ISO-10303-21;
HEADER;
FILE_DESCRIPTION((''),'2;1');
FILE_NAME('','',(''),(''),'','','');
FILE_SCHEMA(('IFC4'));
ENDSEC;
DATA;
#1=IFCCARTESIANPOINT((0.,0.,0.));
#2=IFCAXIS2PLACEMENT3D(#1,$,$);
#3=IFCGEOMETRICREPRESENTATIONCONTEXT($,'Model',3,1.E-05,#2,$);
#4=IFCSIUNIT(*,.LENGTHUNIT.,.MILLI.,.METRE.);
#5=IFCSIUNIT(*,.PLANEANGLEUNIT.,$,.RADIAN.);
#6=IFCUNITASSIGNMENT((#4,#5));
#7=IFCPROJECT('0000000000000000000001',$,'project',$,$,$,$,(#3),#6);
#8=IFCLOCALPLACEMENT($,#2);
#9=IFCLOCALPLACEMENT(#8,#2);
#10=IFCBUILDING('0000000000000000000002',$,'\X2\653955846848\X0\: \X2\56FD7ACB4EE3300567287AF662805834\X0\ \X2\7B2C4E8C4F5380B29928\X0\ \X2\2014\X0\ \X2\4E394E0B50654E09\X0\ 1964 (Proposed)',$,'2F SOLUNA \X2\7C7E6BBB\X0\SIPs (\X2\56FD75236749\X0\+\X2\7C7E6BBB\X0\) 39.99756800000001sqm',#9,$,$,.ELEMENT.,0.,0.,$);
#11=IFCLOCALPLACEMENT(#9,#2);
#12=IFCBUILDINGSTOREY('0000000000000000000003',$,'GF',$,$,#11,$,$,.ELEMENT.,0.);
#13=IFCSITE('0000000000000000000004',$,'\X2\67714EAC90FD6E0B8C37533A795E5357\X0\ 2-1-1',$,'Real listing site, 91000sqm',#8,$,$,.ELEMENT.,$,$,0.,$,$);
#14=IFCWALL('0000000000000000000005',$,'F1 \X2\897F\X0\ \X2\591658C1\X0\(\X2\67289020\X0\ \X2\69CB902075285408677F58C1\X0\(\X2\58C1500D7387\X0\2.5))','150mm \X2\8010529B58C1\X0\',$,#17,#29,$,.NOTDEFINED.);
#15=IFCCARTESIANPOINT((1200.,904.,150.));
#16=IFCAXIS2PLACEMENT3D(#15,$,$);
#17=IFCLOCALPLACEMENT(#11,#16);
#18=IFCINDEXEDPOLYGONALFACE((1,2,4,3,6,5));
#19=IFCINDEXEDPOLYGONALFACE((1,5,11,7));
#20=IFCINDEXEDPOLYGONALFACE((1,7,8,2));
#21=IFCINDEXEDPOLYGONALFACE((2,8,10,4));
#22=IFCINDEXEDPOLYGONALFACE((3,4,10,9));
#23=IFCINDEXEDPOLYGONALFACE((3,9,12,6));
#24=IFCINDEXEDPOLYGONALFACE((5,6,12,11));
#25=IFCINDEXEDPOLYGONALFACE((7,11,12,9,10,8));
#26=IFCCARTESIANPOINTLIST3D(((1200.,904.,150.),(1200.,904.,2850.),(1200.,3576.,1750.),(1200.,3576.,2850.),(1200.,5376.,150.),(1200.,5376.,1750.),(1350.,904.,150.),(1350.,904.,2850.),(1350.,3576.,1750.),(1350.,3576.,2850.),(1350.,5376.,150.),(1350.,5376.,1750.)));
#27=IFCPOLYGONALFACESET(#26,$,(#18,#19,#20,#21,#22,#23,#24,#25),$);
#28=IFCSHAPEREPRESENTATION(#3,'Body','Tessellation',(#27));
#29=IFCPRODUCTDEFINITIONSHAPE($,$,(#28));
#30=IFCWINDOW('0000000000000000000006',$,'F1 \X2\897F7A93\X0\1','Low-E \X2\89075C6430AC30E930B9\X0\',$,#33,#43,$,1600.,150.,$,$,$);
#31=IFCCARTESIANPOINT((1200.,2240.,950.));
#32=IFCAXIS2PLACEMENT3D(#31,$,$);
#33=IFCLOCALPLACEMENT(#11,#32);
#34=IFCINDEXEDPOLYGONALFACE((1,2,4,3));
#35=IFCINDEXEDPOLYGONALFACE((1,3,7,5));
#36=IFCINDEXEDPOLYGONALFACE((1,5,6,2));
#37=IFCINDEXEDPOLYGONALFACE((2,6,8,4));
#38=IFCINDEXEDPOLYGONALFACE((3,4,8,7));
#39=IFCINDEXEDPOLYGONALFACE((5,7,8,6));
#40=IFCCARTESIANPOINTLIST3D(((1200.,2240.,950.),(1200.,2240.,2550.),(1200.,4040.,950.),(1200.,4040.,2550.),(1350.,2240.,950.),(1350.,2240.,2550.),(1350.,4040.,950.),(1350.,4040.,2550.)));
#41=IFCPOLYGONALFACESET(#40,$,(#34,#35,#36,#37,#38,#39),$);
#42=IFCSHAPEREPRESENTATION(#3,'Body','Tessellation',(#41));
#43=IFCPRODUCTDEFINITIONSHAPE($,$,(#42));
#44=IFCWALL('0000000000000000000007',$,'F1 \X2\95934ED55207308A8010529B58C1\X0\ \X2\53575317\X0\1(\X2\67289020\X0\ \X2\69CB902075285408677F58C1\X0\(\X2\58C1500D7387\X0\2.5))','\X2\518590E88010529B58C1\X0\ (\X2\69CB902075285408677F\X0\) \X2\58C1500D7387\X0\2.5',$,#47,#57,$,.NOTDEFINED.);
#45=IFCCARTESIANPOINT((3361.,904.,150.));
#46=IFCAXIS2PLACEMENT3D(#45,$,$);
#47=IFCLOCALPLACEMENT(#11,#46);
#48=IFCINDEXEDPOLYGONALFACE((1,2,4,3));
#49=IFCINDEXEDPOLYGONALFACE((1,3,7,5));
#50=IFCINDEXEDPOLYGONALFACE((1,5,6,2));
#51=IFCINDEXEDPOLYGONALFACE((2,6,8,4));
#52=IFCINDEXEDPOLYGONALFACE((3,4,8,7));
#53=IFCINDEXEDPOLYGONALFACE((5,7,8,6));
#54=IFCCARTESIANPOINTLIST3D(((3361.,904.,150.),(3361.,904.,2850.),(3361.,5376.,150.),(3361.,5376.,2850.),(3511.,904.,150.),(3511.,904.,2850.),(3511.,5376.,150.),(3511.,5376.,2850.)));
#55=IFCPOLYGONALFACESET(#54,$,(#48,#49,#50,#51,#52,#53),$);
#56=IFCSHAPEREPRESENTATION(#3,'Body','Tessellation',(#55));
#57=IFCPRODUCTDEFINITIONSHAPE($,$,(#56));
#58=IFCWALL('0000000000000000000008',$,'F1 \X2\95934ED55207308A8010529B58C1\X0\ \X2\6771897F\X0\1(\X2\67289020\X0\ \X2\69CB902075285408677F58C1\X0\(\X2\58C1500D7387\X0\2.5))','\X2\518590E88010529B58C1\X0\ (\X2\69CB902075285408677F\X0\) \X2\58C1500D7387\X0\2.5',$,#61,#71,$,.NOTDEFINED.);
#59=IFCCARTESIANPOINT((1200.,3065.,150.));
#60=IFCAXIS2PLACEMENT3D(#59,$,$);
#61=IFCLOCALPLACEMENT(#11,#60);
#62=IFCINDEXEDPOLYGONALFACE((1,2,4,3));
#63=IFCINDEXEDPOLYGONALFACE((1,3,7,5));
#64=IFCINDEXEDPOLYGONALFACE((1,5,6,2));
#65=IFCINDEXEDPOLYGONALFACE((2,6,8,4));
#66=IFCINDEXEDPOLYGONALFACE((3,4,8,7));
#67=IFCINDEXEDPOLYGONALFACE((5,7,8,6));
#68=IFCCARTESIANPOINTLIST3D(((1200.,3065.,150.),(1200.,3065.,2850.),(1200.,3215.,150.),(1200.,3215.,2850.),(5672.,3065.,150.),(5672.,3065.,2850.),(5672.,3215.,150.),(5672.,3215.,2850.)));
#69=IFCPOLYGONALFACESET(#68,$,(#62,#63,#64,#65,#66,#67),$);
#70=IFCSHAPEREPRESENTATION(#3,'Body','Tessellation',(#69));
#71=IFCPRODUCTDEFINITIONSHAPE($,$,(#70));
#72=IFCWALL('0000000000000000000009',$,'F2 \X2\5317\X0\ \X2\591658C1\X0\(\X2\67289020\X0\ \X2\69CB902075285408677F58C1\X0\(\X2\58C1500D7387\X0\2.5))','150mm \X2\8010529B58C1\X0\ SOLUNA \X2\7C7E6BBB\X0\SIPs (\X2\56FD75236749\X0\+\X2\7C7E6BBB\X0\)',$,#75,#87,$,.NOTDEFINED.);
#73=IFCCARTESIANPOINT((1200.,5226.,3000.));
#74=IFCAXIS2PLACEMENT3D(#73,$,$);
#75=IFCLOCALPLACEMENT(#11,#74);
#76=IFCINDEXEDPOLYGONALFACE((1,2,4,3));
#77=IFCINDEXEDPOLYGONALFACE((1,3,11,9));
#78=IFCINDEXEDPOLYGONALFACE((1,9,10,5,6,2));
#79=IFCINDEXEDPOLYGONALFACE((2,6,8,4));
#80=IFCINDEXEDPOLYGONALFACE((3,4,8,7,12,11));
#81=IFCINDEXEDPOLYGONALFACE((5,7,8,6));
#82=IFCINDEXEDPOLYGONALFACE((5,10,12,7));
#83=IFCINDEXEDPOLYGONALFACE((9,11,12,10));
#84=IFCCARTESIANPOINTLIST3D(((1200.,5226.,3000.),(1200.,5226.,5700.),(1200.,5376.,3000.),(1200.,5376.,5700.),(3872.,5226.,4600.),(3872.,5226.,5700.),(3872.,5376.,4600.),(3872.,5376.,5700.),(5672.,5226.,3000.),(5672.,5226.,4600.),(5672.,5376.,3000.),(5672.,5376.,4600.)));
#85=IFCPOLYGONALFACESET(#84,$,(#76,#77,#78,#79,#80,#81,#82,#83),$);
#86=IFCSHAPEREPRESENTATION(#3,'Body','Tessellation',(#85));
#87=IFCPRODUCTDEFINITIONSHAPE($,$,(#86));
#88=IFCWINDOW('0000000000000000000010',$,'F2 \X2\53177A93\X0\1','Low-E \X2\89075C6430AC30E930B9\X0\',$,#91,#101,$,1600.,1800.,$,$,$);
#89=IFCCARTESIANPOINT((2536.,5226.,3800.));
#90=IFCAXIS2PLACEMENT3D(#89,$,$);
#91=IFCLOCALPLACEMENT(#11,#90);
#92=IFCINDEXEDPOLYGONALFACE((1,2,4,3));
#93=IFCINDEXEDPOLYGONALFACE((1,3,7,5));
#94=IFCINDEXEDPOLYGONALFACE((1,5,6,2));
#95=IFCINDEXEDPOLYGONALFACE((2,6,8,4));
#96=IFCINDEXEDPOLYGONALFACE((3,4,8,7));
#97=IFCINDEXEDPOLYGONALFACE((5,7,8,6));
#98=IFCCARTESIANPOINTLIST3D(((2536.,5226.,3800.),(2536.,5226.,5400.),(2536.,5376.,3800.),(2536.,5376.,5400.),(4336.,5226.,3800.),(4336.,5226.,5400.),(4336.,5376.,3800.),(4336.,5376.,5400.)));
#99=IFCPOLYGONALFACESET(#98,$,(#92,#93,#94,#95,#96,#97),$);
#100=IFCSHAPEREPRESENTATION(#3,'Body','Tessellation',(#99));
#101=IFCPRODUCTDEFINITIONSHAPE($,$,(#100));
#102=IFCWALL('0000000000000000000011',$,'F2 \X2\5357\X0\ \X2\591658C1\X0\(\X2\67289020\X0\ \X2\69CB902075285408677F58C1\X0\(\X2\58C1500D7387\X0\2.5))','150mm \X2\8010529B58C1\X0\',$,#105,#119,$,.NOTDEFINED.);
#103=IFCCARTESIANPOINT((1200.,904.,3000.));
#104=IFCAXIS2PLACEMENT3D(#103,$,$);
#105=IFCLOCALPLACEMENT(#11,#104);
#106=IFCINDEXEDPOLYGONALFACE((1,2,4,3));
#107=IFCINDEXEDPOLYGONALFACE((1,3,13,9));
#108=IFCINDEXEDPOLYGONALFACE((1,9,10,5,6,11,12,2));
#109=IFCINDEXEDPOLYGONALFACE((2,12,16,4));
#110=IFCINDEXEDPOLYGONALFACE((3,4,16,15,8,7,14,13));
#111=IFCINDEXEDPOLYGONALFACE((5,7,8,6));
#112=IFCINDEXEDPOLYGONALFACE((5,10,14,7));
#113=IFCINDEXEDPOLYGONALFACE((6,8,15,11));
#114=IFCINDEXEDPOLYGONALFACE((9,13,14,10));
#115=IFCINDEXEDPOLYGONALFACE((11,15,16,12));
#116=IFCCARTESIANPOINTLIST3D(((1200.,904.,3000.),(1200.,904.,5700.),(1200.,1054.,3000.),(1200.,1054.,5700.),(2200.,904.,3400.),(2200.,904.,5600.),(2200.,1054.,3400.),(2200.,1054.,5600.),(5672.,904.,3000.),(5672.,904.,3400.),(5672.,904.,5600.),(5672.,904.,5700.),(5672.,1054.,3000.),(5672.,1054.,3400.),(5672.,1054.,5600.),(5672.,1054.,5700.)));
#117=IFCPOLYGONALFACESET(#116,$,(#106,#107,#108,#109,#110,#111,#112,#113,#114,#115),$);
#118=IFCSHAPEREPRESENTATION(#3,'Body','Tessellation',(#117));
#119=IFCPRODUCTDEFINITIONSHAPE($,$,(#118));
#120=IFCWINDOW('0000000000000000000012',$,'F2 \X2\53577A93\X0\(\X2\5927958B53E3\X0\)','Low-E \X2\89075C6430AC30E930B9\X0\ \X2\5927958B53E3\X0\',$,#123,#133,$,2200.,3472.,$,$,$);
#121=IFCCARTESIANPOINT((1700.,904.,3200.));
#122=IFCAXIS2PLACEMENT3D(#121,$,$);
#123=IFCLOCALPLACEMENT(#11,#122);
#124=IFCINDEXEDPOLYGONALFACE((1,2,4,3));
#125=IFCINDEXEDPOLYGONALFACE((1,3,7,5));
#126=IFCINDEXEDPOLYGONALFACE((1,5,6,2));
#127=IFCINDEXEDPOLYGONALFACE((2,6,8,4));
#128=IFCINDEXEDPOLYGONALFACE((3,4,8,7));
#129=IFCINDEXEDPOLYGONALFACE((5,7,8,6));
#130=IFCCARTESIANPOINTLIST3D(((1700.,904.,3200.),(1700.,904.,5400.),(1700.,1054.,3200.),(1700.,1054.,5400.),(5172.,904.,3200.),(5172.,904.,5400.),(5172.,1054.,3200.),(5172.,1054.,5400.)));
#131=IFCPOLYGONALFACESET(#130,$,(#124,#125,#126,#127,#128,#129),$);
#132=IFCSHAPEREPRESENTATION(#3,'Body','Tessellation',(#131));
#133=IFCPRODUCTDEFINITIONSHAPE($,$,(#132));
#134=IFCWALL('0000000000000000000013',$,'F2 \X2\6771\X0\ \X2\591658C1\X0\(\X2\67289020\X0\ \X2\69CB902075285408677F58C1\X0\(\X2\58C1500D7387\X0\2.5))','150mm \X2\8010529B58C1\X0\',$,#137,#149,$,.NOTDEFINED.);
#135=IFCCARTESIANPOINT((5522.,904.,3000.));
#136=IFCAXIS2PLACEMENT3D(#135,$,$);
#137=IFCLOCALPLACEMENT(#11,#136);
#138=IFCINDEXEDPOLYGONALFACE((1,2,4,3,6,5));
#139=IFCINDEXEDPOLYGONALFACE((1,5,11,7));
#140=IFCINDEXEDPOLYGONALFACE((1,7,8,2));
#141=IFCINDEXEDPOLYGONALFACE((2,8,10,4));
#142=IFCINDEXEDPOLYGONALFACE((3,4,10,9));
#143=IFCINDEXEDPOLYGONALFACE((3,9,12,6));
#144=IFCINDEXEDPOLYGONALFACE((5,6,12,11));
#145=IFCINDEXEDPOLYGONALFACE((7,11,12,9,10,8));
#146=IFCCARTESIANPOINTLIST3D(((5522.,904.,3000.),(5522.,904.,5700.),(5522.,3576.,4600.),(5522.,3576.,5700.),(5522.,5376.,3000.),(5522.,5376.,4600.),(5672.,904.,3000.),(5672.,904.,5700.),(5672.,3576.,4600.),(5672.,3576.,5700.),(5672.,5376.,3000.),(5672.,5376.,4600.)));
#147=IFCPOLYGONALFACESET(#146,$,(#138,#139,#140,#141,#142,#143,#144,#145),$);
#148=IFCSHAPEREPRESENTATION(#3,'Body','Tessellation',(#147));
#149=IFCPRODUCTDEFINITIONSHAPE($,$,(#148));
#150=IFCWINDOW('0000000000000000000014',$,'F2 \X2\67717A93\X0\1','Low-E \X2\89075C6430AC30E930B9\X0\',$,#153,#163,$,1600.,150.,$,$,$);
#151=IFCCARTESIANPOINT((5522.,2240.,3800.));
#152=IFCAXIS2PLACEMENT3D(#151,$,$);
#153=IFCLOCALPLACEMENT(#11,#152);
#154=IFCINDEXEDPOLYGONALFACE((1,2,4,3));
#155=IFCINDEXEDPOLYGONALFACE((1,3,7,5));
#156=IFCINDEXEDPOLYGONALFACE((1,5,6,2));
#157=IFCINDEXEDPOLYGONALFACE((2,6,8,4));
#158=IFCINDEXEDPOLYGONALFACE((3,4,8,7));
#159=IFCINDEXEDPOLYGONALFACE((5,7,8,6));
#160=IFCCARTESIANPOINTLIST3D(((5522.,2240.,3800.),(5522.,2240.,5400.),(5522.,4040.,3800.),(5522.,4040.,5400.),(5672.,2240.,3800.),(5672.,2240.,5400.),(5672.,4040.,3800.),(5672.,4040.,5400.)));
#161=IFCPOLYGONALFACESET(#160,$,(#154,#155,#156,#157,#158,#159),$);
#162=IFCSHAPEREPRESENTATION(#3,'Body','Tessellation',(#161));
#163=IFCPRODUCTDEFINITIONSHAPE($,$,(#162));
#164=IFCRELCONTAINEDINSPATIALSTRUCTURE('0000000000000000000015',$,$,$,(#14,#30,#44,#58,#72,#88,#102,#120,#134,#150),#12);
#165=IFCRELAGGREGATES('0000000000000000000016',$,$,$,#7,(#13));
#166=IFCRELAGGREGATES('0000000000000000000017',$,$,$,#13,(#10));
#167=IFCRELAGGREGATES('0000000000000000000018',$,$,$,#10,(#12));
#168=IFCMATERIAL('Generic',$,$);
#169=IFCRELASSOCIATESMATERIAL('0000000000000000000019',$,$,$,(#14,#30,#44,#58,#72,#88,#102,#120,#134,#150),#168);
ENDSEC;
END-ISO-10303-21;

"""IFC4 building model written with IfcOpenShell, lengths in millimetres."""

from ifc_helpers import new_model, si_unit, frame, frame_2d, origin, place, context, project, spatial, rectangle, extrude, material, element, fill, save


model = new_model("IFC4")

# Units and contexts
model_context = context("Model", 3, precision=1e-05, world=origin())
ifc_project = project(units=[si_unit("LENGTHUNIT", "METRE", prefix="MILLI"), si_unit("PLANEANGLEUNIT", "RADIAN")], contexts=[model_context])

# Site, building, storey
site_placement = place(None, origin())
site = spatial("IfcSite", under=ifc_project, at=site_placement, Name="東京都渋谷区神南 2-1-1", ObjectType="Real listing site, 91000sqm", CompositionType="ELEMENT", RefElevation=0.0)
building_placement = place(site_placement, origin())
building = spatial("IfcBuilding", under=site, at=building_placement, Name="改善案: 国立代々木競技場 第二体育館 — 丹下健三 1964 (Proposed)", ObjectType="2F SOLUNA 籾殻SIPs (国産杉+籾殻) 39.99756800000001sqm", CompositionType="ELEMENT", ElevationOfRefHeight=0.0, ElevationOfTerrain=0.0)
storey_placement = place(building_placement, origin())
storey = spatial("IfcBuildingStorey", under=building, at=storey_placement, Name="GF", CompositionType="ELEMENT", Elevation=0.0)

# Shared definitions
ifc_material_1 = material(Name="Generic")

# Wall, opening, window
wall_1_placement = place(storey_placement, frame((1200.0, 904.0, 150.0)))
wall_1 = element("IfcWall", 1, at=wall_1_placement, inside=storey, material=ifc_material_1, Name="F1 西 外壁(木造 構造用合板壁(壁倍率2.5))", Description="150mm 耐力壁", PredefinedType="NOTDEFINED", context=model_context, shape_type="SweptSolid", body=[
    extrude(rectangle(XDim=150.0, YDim=4472.0, at=frame_2d((75.0, 2236.0))), frame((1200.0, 904.0, 150.0)), (0.0, 0.0, 1.0), 2700.0),
])
opening_1_placement = place(storey_placement, frame((1200.0, 2240.0, 950.0)))
opening_1 = element("IfcOpeningElement", 2, at=opening_1_placement, cuts=wall_1, PredefinedType="NOTDEFINED", context=model_context, shape_type="SweptSolid", body=[
    extrude(rectangle(XDim=150.0, YDim=1800.0, at=frame_2d((75.0, 900.0))), frame((1200.0, 2240.0, 950.0)), (0.0, 0.0, 1.0), 1600.0),
])
window_1_placement = place(storey_placement, frame((1200.0, 2240.0, 950.0)))
window_1 = element("IfcWindow", 3, at=window_1_placement, inside=storey, material=ifc_material_1, Name="F1 西窓1", Description="Low-E 複層ガラス", OverallHeight=1600.0, OverallWidth=150.0, context=model_context, shape_type="SweptSolid", body=[
    extrude(rectangle(XDim=150.0, YDim=1800.0, at=frame_2d((75.0, 900.0))), frame((1200.0, 2240.0, 950.0)), (0.0, 0.0, 1.0), 1600.0),
])
fill(opening_1, window_1)

# Walls
wall_2_placement = place(storey_placement, frame((3361.0, 904.0, 150.0)))
element("IfcWall", 4, at=wall_2_placement, inside=storey, material=ifc_material_1, Name="F1 間仕切り耐力壁 南北1(木造 構造用合板壁(壁倍率2.5))", Description="内部耐力壁 (構造用合板) 壁倍率2.5", PredefinedType="NOTDEFINED", context=model_context, shape_type="SweptSolid", body=[
    extrude(rectangle(XDim=150.0, YDim=4472.0, at=frame_2d((75.0, 2236.0))), frame((3361.0, 904.0, 150.0)), (0.0, 0.0, 1.0), 2700.0),
])
wall_3_placement = place(storey_placement, frame((1200.0, 3065.0, 150.0)))
element("IfcWall", 5, at=wall_3_placement, inside=storey, material=ifc_material_1, Name="F1 間仕切り耐力壁 東西1(木造 構造用合板壁(壁倍率2.5))", Description="内部耐力壁 (構造用合板) 壁倍率2.5", PredefinedType="NOTDEFINED", context=model_context, shape_type="SweptSolid", body=[
    extrude(rectangle(XDim=4472.0, YDim=150.0, at=frame_2d((2236.0, 75.0))), frame((1200.0, 3065.0, 150.0)), (0.0, 0.0, 1.0), 2700.0),
])

# Walls, openings, windows
wall_4_placement = place(storey_placement, frame((1200.0, 5226.0, 3000.0)))
wall_4 = element("IfcWall", 6, at=wall_4_placement, inside=storey, material=ifc_material_1, Name="F2 北 外壁(木造 構造用合板壁(壁倍率2.5))", Description="150mm 耐力壁 SOLUNA 籾殻SIPs (国産杉+籾殻)", PredefinedType="NOTDEFINED", context=model_context, shape_type="SweptSolid", body=[
    extrude(rectangle(XDim=4472.0, YDim=150.0, at=frame_2d((2236.0, 75.0))), frame((1200.0, 5226.0, 3000.0)), (0.0, 0.0, 1.0), 2700.0),
])
opening_2_placement = place(storey_placement, frame((2536.0, 5226.0, 3800.0)))
opening_2 = element("IfcOpeningElement", 7, at=opening_2_placement, cuts=wall_4, PredefinedType="NOTDEFINED", context=model_context, shape_type="SweptSolid", body=[
    extrude(rectangle(XDim=1800.0, YDim=150.0, at=frame_2d((900.0, 75.0))), frame((2536.0, 5226.0, 3800.0)), (0.0, 0.0, 1.0), 1600.0),
])
window_2_placement = place(storey_placement, frame((2536.0, 5226.0, 3800.0)))
window_2 = element("IfcWindow", 8, at=window_2_placement, inside=storey, material=ifc_material_1, Name="F2 北窓1", Description="Low-E 複層ガラス", OverallHeight=1600.0, OverallWidth=1800.0, context=model_context, shape_type="SweptSolid", body=[
    extrude(rectangle(XDim=1800.0, YDim=150.0, at=frame_2d((900.0, 75.0))), frame((2536.0, 5226.0, 3800.0)), (0.0, 0.0, 1.0), 1600.0),
])
fill(opening_2, window_2)
wall_5_placement = place(storey_placement, frame((1200.0, 904.0, 3000.0)))
wall_5 = element("IfcWall", 9, at=wall_5_placement, inside=storey, material=ifc_material_1, Name="F2 南 外壁(木造 構造用合板壁(壁倍率2.5))", Description="150mm 耐力壁", PredefinedType="NOTDEFINED", context=model_context, shape_type="SweptSolid", body=[
    extrude(rectangle(XDim=4472.0, YDim=150.0, at=frame_2d((2236.0, 75.0))), frame((1200.0, 904.0, 3000.0)), (0.0, 0.0, 1.0), 2700.0),
])
opening_3_placement = place(storey_placement, frame((1700.0, 904.0, 3200.0)))
opening_3 = element("IfcOpeningElement", 10, at=opening_3_placement, cuts=wall_5, PredefinedType="NOTDEFINED", context=model_context, shape_type="SweptSolid", body=[
    extrude(rectangle(XDim=3472.0, YDim=150.0, at=frame_2d((1736.0, 75.0))), frame((1700.0, 904.0, 3200.0)), (0.0, 0.0, 1.0), 2200.0),
])
window_3_placement = place(storey_placement, frame((1700.0, 904.0, 3200.0)))
window_3 = element("IfcWindow", 11, at=window_3_placement, inside=storey, material=ifc_material_1, Name="F2 南窓(大開口)", Description="Low-E 複層ガラス 大開口", OverallHeight=2200.0, OverallWidth=3472.0, context=model_context, shape_type="SweptSolid", body=[
    extrude(rectangle(XDim=3472.0, YDim=150.0, at=frame_2d((1736.0, 75.0))), frame((1700.0, 904.0, 3200.0)), (0.0, 0.0, 1.0), 2200.0),
])
fill(opening_3, window_3)
wall_6_placement = place(storey_placement, frame((5522.0, 904.0, 3000.0)))
wall_6 = element("IfcWall", 12, at=wall_6_placement, inside=storey, material=ifc_material_1, Name="F2 東 外壁(木造 構造用合板壁(壁倍率2.5))", Description="150mm 耐力壁", PredefinedType="NOTDEFINED", context=model_context, shape_type="SweptSolid", body=[
    extrude(rectangle(XDim=150.0, YDim=4472.0, at=frame_2d((75.0, 2236.0))), frame((5522.0, 904.0, 3000.0)), (0.0, 0.0, 1.0), 2700.0),
])
opening_4_placement = place(storey_placement, frame((5522.0, 2240.0, 3800.0)))
opening_4 = element("IfcOpeningElement", 13, at=opening_4_placement, cuts=wall_6, PredefinedType="NOTDEFINED", context=model_context, shape_type="SweptSolid", body=[
    extrude(rectangle(XDim=150.0, YDim=1800.0, at=frame_2d((75.0, 900.0))), frame((5522.0, 2240.0, 3800.0)), (0.0, 0.0, 1.0), 1600.0),
])
window_4_placement = place(storey_placement, frame((5522.0, 2240.0, 3800.0)))
window_4 = element("IfcWindow", 14, at=window_4_placement, inside=storey, material=ifc_material_1, Name="F2 東窓1", Description="Low-E 複層ガラス", OverallHeight=1600.0, OverallWidth=150.0, context=model_context, shape_type="SweptSolid", body=[
    extrude(rectangle(XDim=150.0, YDim=1800.0, at=frame_2d((75.0, 900.0))), frame((5522.0, 2240.0, 3800.0)), (0.0, 0.0, 1.0), 1600.0),
])
fill(opening_4, window_4)

save(model, "model.ifc")
